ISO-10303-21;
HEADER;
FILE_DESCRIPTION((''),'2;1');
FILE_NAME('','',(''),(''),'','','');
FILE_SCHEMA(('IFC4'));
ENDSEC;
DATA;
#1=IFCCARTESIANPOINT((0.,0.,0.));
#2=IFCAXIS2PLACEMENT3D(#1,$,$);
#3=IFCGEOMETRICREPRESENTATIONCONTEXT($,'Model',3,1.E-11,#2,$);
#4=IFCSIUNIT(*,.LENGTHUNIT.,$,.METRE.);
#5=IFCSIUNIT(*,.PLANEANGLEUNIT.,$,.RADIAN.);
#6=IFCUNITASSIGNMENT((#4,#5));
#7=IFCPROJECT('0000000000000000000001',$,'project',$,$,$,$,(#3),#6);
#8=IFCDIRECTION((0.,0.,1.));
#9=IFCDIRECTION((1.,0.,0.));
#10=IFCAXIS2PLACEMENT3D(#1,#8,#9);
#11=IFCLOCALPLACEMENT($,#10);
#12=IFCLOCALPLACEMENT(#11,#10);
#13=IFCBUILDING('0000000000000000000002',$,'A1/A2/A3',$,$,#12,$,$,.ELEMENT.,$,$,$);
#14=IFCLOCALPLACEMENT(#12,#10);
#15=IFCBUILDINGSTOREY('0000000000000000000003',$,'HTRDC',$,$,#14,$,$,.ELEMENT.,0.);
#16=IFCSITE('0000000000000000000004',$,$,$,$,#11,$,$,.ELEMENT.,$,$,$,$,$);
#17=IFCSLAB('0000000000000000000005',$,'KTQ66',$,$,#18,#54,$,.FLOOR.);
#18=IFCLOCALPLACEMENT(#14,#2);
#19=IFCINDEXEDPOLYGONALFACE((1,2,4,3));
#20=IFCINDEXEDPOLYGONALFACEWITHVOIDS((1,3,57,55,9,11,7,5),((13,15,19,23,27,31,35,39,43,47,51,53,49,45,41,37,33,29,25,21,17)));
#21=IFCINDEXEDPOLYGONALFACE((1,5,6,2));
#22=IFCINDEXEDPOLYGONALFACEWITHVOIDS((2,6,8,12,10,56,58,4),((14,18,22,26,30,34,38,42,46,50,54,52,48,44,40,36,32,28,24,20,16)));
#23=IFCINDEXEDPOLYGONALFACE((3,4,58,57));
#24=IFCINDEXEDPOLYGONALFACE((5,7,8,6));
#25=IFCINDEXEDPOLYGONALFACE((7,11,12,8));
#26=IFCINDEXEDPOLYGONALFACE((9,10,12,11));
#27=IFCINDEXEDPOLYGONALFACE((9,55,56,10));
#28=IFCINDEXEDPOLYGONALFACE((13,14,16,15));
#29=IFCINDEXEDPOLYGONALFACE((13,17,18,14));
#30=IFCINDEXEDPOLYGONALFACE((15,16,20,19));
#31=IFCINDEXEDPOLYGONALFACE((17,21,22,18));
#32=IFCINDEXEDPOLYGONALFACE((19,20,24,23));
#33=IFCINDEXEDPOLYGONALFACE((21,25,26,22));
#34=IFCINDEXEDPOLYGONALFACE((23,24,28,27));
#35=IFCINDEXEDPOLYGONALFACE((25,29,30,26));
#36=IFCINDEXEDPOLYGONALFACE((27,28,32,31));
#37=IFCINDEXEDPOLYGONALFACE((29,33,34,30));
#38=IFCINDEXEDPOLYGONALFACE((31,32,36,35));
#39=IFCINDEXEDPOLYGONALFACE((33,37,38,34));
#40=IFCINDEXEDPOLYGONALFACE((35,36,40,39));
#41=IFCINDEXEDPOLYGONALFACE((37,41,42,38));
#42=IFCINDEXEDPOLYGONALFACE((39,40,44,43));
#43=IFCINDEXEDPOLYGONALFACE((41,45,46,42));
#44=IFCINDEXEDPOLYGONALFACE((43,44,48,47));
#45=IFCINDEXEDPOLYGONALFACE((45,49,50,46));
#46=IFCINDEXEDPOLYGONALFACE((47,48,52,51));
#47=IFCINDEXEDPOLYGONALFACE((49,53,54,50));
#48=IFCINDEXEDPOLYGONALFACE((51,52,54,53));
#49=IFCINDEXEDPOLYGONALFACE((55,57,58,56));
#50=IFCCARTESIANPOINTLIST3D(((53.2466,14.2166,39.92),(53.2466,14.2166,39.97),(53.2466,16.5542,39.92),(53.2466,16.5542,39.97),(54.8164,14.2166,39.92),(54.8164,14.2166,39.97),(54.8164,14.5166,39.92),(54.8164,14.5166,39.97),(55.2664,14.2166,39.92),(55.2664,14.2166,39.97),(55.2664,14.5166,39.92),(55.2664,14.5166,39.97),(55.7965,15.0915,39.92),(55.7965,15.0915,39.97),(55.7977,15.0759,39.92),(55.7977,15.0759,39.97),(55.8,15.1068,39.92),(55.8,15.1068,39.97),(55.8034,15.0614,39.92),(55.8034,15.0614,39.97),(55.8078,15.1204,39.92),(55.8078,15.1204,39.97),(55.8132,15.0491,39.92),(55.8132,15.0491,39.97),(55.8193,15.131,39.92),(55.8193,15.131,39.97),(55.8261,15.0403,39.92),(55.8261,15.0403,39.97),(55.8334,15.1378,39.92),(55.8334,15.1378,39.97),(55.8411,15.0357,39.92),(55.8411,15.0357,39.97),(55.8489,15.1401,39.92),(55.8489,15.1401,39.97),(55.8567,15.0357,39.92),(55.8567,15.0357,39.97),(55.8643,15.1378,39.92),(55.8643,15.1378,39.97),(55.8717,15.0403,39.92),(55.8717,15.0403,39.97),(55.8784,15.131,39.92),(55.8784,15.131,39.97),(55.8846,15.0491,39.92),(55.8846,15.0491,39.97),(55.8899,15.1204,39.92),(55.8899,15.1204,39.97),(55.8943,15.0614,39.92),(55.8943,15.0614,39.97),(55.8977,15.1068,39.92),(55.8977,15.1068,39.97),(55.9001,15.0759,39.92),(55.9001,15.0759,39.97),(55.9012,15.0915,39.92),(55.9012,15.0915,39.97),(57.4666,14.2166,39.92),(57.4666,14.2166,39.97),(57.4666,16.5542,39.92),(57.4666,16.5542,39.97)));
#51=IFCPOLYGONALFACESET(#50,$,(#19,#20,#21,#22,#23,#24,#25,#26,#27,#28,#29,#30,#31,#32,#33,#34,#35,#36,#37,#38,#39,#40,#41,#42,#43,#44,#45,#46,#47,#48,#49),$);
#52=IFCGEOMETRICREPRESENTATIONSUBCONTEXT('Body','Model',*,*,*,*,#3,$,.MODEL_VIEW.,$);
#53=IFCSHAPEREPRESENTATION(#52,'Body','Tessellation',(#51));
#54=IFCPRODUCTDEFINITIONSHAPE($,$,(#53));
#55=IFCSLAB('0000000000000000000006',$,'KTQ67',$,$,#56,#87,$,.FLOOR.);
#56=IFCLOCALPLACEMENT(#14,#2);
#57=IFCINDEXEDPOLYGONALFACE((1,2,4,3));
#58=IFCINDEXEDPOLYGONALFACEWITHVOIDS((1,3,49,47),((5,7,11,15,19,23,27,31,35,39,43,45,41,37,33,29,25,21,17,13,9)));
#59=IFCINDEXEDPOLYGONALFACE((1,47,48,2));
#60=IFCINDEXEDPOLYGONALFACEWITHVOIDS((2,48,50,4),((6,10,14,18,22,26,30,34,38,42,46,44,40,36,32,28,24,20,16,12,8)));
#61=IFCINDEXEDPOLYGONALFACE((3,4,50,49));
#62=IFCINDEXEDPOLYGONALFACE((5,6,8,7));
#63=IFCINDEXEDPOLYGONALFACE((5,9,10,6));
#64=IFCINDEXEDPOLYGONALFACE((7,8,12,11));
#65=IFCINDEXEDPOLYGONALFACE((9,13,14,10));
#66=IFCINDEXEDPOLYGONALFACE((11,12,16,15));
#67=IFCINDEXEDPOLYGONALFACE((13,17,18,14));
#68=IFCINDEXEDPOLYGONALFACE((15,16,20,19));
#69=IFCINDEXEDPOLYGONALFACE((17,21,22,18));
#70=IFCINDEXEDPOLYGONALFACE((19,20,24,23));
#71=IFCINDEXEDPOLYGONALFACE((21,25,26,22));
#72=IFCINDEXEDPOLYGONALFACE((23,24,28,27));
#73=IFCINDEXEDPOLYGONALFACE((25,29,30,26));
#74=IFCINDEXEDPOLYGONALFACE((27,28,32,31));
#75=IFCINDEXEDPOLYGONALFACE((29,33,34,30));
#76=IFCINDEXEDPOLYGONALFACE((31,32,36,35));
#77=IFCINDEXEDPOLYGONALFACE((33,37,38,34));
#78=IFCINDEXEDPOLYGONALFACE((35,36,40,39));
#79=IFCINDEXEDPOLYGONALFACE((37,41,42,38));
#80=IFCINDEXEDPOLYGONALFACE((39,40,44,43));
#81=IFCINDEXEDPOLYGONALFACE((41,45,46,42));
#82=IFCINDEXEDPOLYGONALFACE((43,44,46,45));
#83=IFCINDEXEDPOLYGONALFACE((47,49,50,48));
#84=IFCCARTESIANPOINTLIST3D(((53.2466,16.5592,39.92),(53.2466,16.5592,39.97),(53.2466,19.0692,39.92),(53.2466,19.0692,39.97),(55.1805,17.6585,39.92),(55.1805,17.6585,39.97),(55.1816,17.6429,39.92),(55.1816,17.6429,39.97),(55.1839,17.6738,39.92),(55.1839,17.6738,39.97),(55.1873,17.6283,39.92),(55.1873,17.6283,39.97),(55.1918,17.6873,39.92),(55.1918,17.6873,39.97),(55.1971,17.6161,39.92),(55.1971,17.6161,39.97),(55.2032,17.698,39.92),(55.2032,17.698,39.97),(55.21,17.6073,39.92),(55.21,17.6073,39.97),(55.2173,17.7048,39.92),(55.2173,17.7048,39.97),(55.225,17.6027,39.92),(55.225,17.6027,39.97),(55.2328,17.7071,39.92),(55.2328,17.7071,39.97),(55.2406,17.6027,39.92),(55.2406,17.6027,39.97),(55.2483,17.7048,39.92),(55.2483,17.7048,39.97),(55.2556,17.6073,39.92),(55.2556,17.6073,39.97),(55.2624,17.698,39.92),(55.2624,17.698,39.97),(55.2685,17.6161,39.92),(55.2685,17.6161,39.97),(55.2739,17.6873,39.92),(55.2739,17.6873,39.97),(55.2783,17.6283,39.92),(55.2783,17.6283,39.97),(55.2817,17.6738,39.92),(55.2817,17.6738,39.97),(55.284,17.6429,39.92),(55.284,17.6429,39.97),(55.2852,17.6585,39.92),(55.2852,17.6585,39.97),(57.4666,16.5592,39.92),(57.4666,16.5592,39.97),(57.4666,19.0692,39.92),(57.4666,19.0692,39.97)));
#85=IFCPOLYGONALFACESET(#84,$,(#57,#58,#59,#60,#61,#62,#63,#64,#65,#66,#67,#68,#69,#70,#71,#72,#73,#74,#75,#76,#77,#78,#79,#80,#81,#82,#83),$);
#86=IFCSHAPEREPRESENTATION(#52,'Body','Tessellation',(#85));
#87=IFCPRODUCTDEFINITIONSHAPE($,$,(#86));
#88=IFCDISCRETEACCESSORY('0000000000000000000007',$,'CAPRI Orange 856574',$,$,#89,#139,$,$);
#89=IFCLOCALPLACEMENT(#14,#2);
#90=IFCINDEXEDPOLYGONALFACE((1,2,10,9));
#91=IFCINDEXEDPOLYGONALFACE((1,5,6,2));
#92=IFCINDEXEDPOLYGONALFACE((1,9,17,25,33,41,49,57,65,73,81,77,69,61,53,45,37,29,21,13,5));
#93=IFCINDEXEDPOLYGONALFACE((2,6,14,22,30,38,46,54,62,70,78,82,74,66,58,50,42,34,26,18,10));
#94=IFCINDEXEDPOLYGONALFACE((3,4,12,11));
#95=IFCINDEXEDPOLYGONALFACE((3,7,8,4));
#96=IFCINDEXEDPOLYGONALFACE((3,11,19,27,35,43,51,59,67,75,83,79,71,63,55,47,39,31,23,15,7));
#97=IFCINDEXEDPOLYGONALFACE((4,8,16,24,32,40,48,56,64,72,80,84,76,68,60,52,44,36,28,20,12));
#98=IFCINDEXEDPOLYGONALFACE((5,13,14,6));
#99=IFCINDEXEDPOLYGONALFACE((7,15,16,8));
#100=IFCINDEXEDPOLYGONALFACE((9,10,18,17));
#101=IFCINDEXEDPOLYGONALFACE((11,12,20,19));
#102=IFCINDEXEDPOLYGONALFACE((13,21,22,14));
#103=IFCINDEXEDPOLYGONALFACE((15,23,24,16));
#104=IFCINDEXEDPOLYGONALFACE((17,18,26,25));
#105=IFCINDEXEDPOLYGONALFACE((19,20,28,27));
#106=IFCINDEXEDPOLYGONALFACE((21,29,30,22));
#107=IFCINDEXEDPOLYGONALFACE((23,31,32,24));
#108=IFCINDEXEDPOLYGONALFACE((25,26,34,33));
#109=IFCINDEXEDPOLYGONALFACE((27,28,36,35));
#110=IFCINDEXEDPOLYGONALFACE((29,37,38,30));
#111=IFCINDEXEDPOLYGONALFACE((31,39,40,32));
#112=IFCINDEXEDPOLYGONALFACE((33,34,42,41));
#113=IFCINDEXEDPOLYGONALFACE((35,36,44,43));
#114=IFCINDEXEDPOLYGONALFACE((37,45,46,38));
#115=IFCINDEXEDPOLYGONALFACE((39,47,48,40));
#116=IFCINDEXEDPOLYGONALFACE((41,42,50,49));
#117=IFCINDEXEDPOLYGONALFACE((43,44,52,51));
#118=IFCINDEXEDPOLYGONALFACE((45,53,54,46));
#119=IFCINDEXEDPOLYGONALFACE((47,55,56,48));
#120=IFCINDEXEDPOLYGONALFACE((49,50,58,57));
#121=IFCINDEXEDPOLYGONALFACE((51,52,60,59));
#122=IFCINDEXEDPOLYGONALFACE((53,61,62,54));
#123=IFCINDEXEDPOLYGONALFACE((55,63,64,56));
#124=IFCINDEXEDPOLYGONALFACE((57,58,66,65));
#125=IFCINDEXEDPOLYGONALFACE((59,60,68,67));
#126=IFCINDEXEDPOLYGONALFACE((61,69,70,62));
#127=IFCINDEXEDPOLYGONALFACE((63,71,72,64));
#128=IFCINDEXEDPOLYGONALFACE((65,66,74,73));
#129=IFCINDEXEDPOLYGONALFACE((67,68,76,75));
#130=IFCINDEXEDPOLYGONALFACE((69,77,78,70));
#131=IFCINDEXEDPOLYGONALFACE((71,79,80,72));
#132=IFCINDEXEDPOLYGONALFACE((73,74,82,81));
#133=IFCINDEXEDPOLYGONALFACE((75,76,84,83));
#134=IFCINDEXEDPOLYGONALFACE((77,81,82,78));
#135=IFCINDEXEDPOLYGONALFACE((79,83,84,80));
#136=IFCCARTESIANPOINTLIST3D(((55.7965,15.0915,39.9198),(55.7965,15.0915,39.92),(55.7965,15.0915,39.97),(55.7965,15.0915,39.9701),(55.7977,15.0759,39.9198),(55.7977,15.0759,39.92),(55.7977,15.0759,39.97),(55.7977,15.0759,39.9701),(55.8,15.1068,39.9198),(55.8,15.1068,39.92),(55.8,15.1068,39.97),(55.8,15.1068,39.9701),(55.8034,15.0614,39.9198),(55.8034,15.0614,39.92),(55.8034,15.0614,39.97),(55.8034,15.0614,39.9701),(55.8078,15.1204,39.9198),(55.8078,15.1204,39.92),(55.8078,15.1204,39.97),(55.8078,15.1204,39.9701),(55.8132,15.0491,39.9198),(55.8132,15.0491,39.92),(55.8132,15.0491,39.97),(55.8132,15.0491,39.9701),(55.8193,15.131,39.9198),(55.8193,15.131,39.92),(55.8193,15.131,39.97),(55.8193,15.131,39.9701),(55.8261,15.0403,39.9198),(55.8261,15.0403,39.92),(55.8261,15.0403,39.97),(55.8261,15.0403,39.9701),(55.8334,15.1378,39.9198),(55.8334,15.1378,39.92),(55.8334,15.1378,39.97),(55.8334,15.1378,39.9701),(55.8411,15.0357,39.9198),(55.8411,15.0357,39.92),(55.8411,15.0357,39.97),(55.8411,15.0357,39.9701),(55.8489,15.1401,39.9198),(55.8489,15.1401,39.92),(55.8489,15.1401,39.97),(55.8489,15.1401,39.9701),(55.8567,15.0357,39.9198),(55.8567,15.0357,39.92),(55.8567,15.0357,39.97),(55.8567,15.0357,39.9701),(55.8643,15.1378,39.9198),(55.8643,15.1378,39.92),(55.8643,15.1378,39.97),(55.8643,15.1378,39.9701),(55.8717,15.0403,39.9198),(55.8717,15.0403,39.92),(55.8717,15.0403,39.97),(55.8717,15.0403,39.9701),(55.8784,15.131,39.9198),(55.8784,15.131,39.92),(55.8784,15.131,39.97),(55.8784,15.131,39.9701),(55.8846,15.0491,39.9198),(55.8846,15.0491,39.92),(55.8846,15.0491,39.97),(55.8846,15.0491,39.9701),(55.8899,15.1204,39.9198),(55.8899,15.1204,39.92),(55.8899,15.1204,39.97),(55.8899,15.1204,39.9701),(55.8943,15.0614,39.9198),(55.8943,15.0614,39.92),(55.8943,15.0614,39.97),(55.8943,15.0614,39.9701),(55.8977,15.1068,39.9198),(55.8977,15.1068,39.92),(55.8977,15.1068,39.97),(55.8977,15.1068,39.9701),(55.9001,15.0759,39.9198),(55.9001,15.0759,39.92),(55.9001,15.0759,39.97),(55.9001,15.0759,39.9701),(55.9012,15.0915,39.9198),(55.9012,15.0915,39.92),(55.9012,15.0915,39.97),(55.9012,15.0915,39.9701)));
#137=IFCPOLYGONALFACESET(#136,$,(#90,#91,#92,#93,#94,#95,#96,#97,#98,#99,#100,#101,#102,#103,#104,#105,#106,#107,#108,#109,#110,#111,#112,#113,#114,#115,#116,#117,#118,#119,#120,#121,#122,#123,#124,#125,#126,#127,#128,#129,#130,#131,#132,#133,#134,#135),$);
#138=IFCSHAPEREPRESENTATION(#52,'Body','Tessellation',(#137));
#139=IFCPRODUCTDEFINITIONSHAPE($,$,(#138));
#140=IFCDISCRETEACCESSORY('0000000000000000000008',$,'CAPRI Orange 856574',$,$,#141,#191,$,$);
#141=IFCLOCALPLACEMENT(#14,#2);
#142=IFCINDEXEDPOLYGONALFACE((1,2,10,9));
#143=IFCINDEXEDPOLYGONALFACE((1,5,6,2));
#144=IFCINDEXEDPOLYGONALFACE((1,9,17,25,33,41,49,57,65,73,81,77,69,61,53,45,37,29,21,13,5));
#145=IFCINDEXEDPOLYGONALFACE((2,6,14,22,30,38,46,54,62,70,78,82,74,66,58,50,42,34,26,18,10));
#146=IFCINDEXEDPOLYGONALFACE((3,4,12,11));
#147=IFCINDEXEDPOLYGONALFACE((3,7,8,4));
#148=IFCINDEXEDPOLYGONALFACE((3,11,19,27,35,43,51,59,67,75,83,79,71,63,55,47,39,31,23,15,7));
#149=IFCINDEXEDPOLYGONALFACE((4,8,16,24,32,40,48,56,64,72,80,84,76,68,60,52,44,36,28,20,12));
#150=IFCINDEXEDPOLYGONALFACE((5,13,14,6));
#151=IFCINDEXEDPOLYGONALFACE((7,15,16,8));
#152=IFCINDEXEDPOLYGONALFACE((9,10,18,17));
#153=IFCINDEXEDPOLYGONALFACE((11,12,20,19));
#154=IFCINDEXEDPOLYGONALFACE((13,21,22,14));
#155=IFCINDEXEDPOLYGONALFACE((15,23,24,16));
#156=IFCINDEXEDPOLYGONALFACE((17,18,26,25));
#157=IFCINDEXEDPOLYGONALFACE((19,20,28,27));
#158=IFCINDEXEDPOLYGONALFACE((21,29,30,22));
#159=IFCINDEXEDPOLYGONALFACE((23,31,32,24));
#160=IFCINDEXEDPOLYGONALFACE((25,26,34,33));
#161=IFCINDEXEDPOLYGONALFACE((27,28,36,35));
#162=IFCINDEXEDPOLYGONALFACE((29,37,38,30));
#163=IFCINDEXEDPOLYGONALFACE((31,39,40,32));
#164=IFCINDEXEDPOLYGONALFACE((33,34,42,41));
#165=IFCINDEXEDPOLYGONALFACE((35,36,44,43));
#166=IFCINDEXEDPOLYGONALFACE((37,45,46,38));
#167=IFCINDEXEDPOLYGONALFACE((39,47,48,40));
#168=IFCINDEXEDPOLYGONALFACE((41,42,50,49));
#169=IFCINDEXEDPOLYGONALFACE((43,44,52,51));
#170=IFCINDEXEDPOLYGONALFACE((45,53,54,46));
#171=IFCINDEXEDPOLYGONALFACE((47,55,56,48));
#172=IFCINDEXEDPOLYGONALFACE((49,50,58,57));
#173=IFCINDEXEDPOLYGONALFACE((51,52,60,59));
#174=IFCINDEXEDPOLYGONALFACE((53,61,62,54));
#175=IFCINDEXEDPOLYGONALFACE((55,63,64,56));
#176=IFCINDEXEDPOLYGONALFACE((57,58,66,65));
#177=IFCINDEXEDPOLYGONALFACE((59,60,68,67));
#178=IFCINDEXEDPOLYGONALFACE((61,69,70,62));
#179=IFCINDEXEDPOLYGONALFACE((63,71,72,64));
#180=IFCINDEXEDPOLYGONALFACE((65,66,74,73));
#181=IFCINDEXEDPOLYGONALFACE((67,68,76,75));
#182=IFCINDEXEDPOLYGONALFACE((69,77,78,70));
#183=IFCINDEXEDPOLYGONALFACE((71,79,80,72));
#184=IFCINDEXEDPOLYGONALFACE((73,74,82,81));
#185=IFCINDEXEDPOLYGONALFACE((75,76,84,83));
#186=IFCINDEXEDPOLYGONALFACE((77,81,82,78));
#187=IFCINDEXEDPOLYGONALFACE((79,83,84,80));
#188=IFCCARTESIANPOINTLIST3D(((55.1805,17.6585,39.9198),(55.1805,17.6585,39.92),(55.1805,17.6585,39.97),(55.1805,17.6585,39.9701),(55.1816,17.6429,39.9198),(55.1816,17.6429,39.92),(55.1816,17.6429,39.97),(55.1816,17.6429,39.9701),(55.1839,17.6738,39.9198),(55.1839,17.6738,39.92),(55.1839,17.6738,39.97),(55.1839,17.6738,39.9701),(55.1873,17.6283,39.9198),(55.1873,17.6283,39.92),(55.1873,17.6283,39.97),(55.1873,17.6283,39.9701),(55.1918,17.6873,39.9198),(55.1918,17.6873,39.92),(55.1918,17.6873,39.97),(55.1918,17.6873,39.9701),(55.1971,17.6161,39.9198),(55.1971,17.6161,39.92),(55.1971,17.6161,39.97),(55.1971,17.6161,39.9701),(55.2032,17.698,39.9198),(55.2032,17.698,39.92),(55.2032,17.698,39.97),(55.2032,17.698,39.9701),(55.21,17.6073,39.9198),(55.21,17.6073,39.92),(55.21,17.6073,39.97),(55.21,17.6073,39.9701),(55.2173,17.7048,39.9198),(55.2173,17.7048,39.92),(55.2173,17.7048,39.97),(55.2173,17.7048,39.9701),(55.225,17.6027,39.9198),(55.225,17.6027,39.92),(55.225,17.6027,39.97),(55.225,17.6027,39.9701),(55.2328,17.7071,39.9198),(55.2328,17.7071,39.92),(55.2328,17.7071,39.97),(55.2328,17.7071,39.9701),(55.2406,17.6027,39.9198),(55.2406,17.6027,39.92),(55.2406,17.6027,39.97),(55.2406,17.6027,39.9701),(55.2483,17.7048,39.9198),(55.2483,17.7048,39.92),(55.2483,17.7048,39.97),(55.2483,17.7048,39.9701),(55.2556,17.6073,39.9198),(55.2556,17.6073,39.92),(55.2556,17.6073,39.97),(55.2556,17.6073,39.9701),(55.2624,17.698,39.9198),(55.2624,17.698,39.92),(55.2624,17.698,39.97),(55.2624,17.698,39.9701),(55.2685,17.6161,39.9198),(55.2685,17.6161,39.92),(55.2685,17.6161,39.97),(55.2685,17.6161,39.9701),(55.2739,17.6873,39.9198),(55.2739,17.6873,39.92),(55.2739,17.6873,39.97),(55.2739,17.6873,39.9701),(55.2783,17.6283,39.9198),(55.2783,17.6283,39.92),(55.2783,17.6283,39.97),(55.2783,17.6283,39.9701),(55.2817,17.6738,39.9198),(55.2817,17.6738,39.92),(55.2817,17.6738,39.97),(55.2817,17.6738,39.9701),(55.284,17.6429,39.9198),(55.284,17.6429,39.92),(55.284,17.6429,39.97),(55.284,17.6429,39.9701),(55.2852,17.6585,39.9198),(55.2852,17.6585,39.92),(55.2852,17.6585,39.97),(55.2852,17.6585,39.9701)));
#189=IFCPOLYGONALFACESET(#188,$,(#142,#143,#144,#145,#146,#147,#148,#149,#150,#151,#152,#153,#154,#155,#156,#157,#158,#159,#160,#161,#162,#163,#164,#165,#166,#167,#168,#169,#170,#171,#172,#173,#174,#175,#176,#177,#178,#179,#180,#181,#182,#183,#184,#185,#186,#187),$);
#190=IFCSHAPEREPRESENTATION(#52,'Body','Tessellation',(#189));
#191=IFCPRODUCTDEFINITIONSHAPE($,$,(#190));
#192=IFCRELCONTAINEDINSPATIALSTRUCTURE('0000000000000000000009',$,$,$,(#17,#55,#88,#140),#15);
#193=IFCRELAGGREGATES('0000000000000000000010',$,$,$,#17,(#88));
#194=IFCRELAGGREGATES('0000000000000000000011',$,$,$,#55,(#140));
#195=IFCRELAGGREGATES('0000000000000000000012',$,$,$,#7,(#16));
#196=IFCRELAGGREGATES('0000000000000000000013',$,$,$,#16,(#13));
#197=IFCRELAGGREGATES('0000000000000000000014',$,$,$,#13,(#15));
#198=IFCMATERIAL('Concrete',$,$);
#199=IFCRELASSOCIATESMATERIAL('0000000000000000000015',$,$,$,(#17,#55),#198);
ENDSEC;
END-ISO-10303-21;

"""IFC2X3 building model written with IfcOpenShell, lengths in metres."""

from ifc_helpers import new_model, si_unit, frame, frame_2d, origin, origin_with_axes, origin_2d_with_axis, place, context, subcontext, project, spatial, polyline, circle, outline, extrude, material, element, aggregate, save


model = new_model("IFC2X3")

# Units and contexts
model_context = context("Model", 3, precision=1e-11, world=origin())
body_context = subcontext(model_context, "Body", "Model", "MODEL_VIEW")
ifc_project = project(units=[si_unit("LENGTHUNIT", "METRE"), si_unit("PLANEANGLEUNIT", "RADIAN")], contexts=[model_context])

# Site, building, storey
site_placement = place(None, origin_with_axes())
site = spatial("IfcSite", under=ifc_project, at=site_placement, CompositionType="ELEMENT")
building_placement = place(site_placement, origin_with_axes())
building = spatial("IfcBuilding", under=site, at=building_placement, Name="A1/A2/A3", CompositionType="ELEMENT")
storey_placement = place(building_placement, origin_with_axes())
storey = spatial("IfcBuildingStorey", under=building, at=storey_placement, Name="HTRDC", CompositionType="ELEMENT", Elevation=0.0)

# Shared definitions
ifc_material = material(Name="Concrete")

# Slab, openings
slab_1_placement = place(storey_placement, frame((53.2466, 14.2166, 39.92), z_axis=(0.0, 0.0, 1.0), x_axis=(1.0, 0.0, 0.0)))
slab_1 = element("IfcSlab", 1, at=slab_1_placement, inside=storey, material=ifc_material, Name="KTQ66", PredefinedType="FLOOR", context=body_context, shape_type="SweptSolid", body=[
    extrude(outline(polyline([(0.0, 0.0), (0.0, -4.22), (2.3375, -4.22), (2.3375, 0.0), (0.0, 0.0)])), frame((0.0, 0.0, 0.0), z_axis=(0.0, 0.0, 1.0), x_axis=(0.0, 1.0, 0.0)), (0.0, 0.0, 1.0), 0.05),
])
opening_1_placement = place(slab_1_placement, origin_with_axes())
element("IfcOpeningElement", 2, at=opening_1_placement, cuts=slab_1, ObjectType="Opening", context=body_context, shape_type="SweptSolid", body=[
    extrude(outline(polyline([(0.0, -1.5698), (0.0, -2.0198), (0.3, -2.0198), (0.3, -1.5698), (0.0, -1.5698)])), frame((0.0, 0.0, 0.0), z_axis=(0.0, 0.0, 1.0), x_axis=(0.0, 1.0, 0.0)), (0.0, 0.0, 1.0), 0.05),
])
opening_2_placement = place(slab_1_placement, frame((2.6023, 0.871, 0.0), z_axis=(0.0, 0.0, 1.0), x_axis=(1.0, 0.0, 0.0)))
element("IfcOpeningElement", 3, at=opening_2_placement, cuts=slab_1, ObjectType="Opening", context=body_context, shape_type="SweptSolid", body=[
    extrude(circle(Radius=0.0525, at=origin_2d_with_axis()), frame((0.0, 0.0, 0.0), z_axis=(0.0, 0.0, 1.0), x_axis=(0.0, 1.0, 0.0)), (0.0, 0.0, 1.0), 0.05),
])

# Slab, opening
slab_2_placement = place(storey_placement, frame((53.2466, 16.5592, 39.92), z_axis=(0.0, 0.0, 1.0), x_axis=(1.0, 0.0, 0.0)))
slab_2 = element("IfcSlab", 4, at=slab_2_placement, inside=storey, material=ifc_material, Name="KTQ67", PredefinedType="FLOOR", context=body_context, shape_type="SweptSolid", body=[
    extrude(outline(polyline([(0.0, 0.0), (0.0, -4.22), (2.51, -4.22), (2.51, 0.0), (0.0, 0.0)])), frame((0.0, 0.0, 0.0), z_axis=(0.0, 0.0, 1.0), x_axis=(0.0, 1.0, 0.0)), (0.0, 0.0, 1.0), 0.05),
])
opening_3_placement = place(slab_2_placement, frame((1.9863, 1.0954, 0.0), z_axis=(0.0, 0.0, 1.0), x_axis=(1.0, 0.0, 0.0)))
element("IfcOpeningElement", 5, at=opening_3_placement, cuts=slab_2, ObjectType="Opening", context=body_context, shape_type="SweptSolid", body=[
    extrude(circle(Radius=0.0525, at=origin_2d_with_axis()), frame((0.0, 0.0, 0.0), z_axis=(0.0, 0.0, 1.0), x_axis=(0.0, 1.0, 0.0)), (0.0, 0.0, 1.0), 0.05),
])

# Discrete accessories
discrete_accessory_1_placement = place(storey_placement, frame((53.2466, 14.2166, 39.9198), z_axis=(0.0, 0.0, 1.0), x_axis=(1.0, 0.0, 0.0)))
discrete_accessory_1 = element("IfcDiscreteAccessory", 6, at=discrete_accessory_1_placement, inside=storey, Name="CAPRI Orange 856574", context=body_context, shape_type="SweptSolid", body=[
    extrude(circle(Radius=0.0525, at=frame_2d((0.871, -2.6023), x_axis=(1.0, 0.0))), frame((0.0, 0.0, 0.0), z_axis=(0.0, 0.0, 1.0), x_axis=(0.0, 1.0, 0.0)), (0.0, 0.0, 1.0), 0.0503),
])
aggregate(slab_1, [discrete_accessory_1])
discrete_accessory_2_placement = place(storey_placement, frame((53.2466, 16.5592, 39.9198), z_axis=(0.0, 0.0, 1.0), x_axis=(1.0, 0.0, 0.0)))
discrete_accessory_2 = element("IfcDiscreteAccessory", 7, at=discrete_accessory_2_placement, inside=storey, Name="CAPRI Orange 856574", context=body_context, shape_type="SweptSolid", body=[
    extrude(circle(Radius=0.0525, at=frame_2d((1.0954, -1.9863), x_axis=(1.0, 0.0))), frame((0.0, 0.0, 0.0), z_axis=(0.0, 0.0, 1.0), x_axis=(0.0, 1.0, 0.0)), (0.0, 0.0, 1.0), 0.0503),
])
aggregate(slab_2, [discrete_accessory_2])

save(model, "model.ifc")
